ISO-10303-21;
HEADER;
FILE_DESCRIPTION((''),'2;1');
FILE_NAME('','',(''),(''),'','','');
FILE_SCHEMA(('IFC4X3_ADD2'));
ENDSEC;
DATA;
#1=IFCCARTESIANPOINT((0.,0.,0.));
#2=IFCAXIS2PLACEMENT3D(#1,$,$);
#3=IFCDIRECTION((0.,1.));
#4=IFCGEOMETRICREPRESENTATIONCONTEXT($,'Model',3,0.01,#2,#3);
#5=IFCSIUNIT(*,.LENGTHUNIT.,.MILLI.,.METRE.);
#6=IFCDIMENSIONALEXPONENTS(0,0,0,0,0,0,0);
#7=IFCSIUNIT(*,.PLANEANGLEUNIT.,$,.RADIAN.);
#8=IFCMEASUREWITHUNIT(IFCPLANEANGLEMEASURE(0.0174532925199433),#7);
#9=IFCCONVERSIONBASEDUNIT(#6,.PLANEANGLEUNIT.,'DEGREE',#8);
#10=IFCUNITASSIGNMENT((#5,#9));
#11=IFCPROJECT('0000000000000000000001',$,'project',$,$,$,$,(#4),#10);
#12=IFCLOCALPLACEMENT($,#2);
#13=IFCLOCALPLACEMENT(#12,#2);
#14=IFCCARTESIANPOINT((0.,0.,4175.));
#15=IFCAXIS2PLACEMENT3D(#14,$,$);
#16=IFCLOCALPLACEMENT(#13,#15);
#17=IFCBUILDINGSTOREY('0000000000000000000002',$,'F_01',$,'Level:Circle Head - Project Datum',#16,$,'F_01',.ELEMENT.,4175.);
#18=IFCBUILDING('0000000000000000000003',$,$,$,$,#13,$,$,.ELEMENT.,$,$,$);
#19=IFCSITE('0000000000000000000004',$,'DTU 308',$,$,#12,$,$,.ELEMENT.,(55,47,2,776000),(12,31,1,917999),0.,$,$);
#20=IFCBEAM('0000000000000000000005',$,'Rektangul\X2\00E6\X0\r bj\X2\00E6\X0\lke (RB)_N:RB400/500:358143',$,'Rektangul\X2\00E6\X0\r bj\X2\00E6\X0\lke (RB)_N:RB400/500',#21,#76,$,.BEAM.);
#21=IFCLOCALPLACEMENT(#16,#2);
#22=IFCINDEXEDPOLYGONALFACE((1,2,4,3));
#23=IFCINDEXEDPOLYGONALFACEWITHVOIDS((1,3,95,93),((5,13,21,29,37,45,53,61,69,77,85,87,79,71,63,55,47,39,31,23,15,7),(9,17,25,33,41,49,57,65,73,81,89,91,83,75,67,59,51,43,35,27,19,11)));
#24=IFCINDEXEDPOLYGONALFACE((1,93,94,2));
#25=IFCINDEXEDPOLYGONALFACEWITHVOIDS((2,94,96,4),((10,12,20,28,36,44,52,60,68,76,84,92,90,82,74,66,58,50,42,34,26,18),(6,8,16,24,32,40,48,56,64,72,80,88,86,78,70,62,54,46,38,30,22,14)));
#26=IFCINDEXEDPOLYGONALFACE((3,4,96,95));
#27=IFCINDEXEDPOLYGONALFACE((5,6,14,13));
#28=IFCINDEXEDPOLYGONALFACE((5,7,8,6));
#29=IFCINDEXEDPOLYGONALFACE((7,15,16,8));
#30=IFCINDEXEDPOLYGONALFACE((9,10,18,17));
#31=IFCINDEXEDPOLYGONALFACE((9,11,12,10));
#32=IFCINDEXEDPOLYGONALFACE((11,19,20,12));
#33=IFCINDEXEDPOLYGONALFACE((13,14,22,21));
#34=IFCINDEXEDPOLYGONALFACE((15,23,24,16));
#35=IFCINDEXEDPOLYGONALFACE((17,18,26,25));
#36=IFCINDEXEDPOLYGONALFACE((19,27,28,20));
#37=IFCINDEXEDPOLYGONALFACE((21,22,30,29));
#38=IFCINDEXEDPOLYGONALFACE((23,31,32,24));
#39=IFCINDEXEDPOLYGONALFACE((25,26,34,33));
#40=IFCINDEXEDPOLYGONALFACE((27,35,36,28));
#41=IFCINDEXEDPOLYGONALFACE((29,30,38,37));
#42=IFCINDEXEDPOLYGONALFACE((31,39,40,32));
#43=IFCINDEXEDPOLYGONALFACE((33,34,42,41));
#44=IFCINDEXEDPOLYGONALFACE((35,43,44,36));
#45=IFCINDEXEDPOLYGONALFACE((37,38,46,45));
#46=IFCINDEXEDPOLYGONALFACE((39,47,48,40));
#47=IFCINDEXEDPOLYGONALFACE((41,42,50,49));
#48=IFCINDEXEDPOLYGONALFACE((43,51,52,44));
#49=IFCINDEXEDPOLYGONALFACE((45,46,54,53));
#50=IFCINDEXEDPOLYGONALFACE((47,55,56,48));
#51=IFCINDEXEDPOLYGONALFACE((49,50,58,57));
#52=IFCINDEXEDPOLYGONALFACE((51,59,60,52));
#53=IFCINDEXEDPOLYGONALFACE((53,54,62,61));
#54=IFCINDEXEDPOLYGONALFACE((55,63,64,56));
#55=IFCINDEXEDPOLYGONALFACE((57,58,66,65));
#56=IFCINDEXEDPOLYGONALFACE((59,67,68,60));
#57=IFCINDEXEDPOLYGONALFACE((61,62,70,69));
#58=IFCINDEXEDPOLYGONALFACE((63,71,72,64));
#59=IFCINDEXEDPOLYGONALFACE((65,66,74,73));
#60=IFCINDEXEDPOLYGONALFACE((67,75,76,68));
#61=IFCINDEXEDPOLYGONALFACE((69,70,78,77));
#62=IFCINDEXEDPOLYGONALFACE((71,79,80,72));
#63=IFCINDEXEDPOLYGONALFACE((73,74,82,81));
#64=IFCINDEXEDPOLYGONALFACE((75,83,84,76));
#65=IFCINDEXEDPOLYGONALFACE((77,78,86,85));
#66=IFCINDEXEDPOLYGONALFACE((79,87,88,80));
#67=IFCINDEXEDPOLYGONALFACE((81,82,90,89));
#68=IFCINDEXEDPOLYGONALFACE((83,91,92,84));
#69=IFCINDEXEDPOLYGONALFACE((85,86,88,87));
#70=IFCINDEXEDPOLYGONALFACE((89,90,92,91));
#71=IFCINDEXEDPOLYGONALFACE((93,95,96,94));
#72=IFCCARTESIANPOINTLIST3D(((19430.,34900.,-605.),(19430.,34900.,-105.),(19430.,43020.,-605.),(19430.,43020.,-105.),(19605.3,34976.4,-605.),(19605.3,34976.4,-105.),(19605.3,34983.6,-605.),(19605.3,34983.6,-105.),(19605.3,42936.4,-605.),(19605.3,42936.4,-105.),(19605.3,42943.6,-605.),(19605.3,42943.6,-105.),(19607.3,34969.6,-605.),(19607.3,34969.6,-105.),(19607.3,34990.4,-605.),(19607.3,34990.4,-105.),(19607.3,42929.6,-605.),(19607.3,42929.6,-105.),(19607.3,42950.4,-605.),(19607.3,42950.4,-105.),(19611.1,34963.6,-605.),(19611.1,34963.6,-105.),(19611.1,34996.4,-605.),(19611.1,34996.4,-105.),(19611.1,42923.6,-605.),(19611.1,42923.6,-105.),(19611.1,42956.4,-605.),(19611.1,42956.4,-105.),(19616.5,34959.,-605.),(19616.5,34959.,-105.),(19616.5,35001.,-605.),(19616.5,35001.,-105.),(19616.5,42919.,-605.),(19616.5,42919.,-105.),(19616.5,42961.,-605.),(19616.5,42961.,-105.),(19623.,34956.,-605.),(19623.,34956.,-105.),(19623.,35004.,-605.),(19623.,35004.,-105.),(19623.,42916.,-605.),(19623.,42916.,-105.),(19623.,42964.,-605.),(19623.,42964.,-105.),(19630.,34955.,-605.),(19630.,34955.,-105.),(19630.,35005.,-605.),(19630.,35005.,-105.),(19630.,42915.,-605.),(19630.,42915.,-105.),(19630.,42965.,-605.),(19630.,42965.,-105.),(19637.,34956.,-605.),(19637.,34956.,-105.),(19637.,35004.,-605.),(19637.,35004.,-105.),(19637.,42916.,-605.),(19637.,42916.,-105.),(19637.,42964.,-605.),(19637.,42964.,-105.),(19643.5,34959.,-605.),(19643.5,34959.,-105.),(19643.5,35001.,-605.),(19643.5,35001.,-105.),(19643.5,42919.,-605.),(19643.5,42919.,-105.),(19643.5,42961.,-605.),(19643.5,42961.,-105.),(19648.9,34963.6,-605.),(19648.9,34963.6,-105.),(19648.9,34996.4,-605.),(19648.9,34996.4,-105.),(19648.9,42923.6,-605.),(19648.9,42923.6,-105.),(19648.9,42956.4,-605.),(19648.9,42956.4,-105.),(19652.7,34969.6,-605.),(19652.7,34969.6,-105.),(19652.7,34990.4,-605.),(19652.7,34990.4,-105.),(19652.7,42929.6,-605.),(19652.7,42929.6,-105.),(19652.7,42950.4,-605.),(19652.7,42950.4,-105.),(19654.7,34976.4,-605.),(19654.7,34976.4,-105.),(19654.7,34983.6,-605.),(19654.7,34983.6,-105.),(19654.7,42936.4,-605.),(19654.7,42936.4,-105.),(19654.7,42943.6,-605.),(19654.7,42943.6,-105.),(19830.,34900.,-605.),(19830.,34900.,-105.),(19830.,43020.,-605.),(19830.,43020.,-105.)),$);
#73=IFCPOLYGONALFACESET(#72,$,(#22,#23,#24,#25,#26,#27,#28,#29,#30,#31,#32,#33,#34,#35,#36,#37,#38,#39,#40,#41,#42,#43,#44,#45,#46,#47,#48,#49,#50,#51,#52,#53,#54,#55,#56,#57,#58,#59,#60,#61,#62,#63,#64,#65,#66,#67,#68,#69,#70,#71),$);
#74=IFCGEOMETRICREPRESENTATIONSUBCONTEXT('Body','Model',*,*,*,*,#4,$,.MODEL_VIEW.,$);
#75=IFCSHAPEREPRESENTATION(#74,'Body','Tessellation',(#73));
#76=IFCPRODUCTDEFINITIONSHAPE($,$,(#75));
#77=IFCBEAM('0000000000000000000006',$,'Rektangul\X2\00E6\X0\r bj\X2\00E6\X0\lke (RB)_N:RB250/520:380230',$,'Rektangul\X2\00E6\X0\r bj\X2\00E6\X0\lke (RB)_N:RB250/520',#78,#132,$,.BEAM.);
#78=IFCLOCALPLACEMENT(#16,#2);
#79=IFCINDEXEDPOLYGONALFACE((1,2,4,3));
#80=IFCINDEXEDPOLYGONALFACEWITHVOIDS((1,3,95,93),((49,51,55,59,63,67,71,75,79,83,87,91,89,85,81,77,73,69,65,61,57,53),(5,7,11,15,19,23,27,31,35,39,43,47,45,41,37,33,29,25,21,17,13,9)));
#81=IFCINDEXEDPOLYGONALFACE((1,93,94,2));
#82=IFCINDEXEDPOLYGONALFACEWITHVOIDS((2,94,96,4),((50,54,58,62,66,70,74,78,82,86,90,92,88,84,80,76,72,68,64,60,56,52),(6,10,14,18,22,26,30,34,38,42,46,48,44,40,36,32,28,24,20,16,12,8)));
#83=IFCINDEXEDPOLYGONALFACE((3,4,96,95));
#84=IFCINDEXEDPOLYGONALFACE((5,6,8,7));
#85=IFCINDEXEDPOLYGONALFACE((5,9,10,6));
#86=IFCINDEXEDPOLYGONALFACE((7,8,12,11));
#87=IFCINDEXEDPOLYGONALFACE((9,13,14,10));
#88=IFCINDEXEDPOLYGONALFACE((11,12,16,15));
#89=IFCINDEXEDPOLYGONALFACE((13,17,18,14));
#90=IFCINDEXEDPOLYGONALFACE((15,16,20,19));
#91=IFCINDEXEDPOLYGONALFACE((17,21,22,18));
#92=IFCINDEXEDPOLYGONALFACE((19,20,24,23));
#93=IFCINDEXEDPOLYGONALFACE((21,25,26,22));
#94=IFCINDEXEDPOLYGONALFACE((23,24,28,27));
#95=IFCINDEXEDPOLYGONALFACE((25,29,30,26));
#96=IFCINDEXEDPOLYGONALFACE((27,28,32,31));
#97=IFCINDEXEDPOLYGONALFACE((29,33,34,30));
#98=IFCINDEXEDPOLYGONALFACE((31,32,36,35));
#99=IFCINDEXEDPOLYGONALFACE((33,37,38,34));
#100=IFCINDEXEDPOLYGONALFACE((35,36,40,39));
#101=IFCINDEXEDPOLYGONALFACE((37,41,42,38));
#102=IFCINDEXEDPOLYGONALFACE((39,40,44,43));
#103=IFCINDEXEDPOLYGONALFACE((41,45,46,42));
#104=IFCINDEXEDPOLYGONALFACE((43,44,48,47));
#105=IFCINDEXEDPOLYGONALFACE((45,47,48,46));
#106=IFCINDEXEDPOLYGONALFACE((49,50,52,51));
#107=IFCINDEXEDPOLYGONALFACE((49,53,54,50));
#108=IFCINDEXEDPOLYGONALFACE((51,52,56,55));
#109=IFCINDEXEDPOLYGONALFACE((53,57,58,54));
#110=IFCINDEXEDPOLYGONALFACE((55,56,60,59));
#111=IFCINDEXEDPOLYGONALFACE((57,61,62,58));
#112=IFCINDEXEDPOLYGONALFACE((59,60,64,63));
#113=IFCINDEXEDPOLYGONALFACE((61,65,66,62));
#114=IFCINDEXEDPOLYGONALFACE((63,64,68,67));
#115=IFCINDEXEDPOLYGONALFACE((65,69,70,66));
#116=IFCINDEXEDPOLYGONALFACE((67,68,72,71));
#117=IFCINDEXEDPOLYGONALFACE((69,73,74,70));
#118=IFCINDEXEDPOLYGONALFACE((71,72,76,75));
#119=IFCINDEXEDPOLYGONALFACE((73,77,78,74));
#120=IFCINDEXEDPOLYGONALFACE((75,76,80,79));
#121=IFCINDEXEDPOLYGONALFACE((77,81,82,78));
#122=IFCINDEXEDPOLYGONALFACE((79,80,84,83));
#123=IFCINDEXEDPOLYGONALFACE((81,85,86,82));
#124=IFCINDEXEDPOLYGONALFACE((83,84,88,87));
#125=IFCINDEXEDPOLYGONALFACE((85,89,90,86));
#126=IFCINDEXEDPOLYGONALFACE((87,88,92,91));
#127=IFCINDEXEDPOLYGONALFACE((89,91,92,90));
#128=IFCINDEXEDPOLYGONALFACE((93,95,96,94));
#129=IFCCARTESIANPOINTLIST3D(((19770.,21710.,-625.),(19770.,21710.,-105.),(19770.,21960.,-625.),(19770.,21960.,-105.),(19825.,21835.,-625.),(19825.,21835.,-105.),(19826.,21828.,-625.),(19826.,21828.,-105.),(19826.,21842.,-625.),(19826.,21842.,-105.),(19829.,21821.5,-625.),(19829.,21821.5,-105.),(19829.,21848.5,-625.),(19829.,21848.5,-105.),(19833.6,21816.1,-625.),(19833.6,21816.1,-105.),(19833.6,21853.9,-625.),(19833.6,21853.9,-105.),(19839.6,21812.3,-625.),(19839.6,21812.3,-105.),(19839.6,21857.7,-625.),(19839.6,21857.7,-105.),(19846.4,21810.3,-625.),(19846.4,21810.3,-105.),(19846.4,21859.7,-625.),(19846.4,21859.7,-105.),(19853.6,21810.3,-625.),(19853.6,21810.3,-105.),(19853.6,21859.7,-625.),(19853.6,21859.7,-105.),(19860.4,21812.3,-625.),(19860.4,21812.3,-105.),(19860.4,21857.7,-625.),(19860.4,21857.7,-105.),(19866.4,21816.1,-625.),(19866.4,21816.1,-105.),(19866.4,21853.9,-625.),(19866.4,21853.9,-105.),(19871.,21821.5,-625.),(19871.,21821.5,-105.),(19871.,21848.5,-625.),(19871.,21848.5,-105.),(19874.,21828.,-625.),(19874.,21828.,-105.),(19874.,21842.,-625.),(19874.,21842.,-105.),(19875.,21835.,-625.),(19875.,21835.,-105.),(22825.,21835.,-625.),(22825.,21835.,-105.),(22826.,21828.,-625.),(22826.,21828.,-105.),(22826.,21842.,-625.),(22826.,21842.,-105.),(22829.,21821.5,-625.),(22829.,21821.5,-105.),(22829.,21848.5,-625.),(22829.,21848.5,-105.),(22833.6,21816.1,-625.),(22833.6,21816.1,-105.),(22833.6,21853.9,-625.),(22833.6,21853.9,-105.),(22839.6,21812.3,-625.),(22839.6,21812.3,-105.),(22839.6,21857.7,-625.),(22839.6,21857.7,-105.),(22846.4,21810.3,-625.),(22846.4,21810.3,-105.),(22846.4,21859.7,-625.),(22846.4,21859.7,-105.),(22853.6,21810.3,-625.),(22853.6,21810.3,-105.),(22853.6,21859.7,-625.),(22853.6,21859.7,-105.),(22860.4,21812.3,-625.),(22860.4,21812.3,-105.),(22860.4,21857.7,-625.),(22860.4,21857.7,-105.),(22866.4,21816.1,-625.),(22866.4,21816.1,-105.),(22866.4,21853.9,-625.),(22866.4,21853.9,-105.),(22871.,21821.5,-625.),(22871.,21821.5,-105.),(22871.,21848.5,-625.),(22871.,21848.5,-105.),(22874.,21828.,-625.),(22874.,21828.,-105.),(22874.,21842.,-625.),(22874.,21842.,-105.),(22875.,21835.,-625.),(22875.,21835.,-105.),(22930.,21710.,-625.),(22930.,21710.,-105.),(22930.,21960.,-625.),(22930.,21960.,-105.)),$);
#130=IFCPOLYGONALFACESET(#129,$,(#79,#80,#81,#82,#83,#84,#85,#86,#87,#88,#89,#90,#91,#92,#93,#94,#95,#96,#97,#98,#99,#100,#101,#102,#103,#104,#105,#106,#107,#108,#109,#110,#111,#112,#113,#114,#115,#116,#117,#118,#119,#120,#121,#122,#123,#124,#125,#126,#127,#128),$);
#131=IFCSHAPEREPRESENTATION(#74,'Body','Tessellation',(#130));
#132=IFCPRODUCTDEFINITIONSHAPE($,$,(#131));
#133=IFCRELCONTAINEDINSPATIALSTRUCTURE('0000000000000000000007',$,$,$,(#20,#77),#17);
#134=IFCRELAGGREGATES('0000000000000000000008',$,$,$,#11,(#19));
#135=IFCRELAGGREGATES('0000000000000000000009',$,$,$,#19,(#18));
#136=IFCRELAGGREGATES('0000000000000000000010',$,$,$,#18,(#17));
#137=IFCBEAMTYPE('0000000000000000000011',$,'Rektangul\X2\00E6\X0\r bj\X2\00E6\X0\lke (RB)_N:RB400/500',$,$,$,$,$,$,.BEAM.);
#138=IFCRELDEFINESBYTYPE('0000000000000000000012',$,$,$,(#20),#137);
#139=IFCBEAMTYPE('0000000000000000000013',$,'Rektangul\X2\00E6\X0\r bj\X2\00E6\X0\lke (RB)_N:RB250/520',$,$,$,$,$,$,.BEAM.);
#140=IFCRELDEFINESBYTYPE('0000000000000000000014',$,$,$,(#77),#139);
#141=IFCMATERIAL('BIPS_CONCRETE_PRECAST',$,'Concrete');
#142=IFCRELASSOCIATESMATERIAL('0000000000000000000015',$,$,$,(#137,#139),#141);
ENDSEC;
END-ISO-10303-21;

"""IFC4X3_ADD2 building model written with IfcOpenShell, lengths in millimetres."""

from ifc_helpers import new_model, entity, si_unit, converted_unit, direction, frame, frame_2d, origin, place, context, subcontext, project, spatial, polyline, circle_curve, parameter, trimmed, segment, composite_curve, rectangle, outline, extrude, source, transform, mapped, material, material_profile, profile_set, type_object, element, save


model = new_model("IFC4X3_ADD2")

# Units and contexts
model_context = context("Model", 3, precision=0.01, world=origin(), true_north=direction((0.0, 1.0)))
body_context = subcontext(model_context, "Body", "Model", "MODEL_VIEW")
ifc_project = project(units=[si_unit("LENGTHUNIT", "METRE", prefix="MILLI"), converted_unit("PLANEANGLEUNIT", "DEGREE", entity("IfcPlaneAngleMeasure", 0.0174532925199433), si_unit("PLANEANGLEUNIT", "RADIAN"), dimensions=[0, 0, 0, 0, 0, 0, 0])], contexts=[model_context])

# Site, building, storey
site_placement = place(None, origin())
site = spatial("IfcSite", under=ifc_project, at=site_placement, Name="DTU 308", CompositionType="ELEMENT", RefLatitude=(55, 47, 2, 776000), RefLongitude=(12, 31, 1, 917999), RefElevation=0.0)
building_placement = place(site_placement, origin())
building = spatial("IfcBuilding", under=site, at=building_placement, CompositionType="ELEMENT")
storey_placement = place(building_placement, frame((0.0, 0.0, 4175.0)))
storey = spatial("IfcBuildingStorey", under=building, at=storey_placement, Name="F_01", ObjectType="Level:Circle Head - Project Datum", LongName="F_01", CompositionType="ELEMENT", Elevation=4175.0)

# Beams
ifc_material_1 = material(Name="BIPS_CONCRETE_PRECAST", Category="Concrete")
ifc_material_profile_1 = material_profile(ifc_material_1, outline(polyline([(-4060.0, -200.0), (4060.0, -200.0), (4060.0, 200.0), (-4060.0, 200.0), (-4060.0, -200.0)]), holes=[composite_curve([segment(trimmed(circle_curve(frame_2d((3980.0, 0.0), x_axis=(-1.0, 0.0)), 25.0), [parameter(0.0)], [parameter(180.0)], True, "PARAMETER"), False, "CONTINUOUS"), segment(trimmed(circle_curve(frame_2d((3980.0, 0.0), x_axis=(-1.0, 0.0)), 25.0), [parameter(180.0)], [parameter(360.0)], True, "PARAMETER"), False, "CONTINUOUS")], self_intersect=False), composite_curve([segment(trimmed(circle_curve(frame_2d((-3980.0, 0.0), x_axis=(-1.0, 0.0)), 25.0), [parameter(0.0)], [parameter(180.0)], True, "PARAMETER"), False, "CONTINUOUS"), segment(trimmed(circle_curve(frame_2d((-3980.0, 0.0), x_axis=(-1.0, 0.0)), 25.0), [parameter(180.0)], [parameter(360.0)], True, "PARAMETER"), False, "CONTINUOUS")], self_intersect=False)]), Name="RB400/500")
ifc_profile_set_1 = profile_set([ifc_material_profile_1], Name="RB400/500")
beam_type_1 = type_object("IfcBeamType", Name="Rektangulær bjælke (RB)_N:RB400/500", PredefinedType="BEAM", material=ifc_profile_set_1)
shared_shape_1 = source(origin(), body_context, "Body", "SweptSolid", [
    extrude(outline(polyline([(-4060.0, -200.0), (4060.0, -200.0), (4060.0, 200.0), (-4060.0, 200.0), (-4060.0, -200.0)]), holes=[composite_curve([segment(trimmed(circle_curve(frame_2d((3980.0, 0.0), x_axis=(-1.0, 0.0)), 25.0), [parameter(0.0)], [parameter(180.0)], True, "PARAMETER"), False, "CONTINUOUS"), segment(trimmed(circle_curve(frame_2d((3980.0, 0.0), x_axis=(-1.0, 0.0)), 25.0), [parameter(180.0)], [parameter(360.0)], True, "PARAMETER"), False, "CONTINUOUS")], self_intersect=False), composite_curve([segment(trimmed(circle_curve(frame_2d((-3980.0, 0.0), x_axis=(-1.0, 0.0)), 25.0), [parameter(0.0)], [parameter(180.0)], True, "PARAMETER"), False, "CONTINUOUS"), segment(trimmed(circle_curve(frame_2d((-3980.0, 0.0), x_axis=(-1.0, 0.0)), 25.0), [parameter(180.0)], [parameter(360.0)], True, "PARAMETER"), False, "CONTINUOUS")], self_intersect=False)]), frame((10.0, 0.0, -250.0), z_axis=(0.0, 0.0, 1.0), x_axis=(-1.0, 0.0, 0.0)), (0.0, 0.0, 1.0), 500.0),
])
for number, where, z_axis, x_axis, name in (
    (1, (19630.0, 38950.0, -355.0), (0.0, 0.0, 1.0), (0.0, 1.0, 0.0), "Rektangulær bjælke (RB)_N:RB400/500:358143"),
):
    element("IfcBeam", number, at=place(storey_placement, frame(where, z_axis=z_axis, x_axis=x_axis)), inside=storey, type_object=beam_type_1, Name=name, ObjectType="Rektangulær bjælke (RB)_N:RB400/500", PredefinedType="BEAM", context=body_context, shape_type="MappedRepresentation", body=[
        mapped(shared_shape_1, transform((0.0, 0.0, 0.0), scale=1.0)),
    ])
ifc_material_profile_2 = material_profile(ifc_material_1, rectangle(XDim=520.0, YDim=250.0, at=frame_2d((0.0, 0.0), x_axis=(1.0, 0.0))), Name="RB250/520")
ifc_profile_set_2 = profile_set([ifc_material_profile_2], Name="RB250/520")
beam_type_2 = type_object("IfcBeamType", Name="Rektangulær bjælke (RB)_N:RB250/520", PredefinedType="BEAM", material=ifc_profile_set_2)
shared_shape_2 = source(origin(), body_context, "Body", "SweptSolid", [
    extrude(outline(polyline([(-1580.0, -125.0), (1580.0, -125.0), (1580.0, 125.0), (-1580.0, 125.0), (-1580.0, -125.0)]), holes=[composite_curve([segment(trimmed(circle_curve(frame_2d((1500.0, 0.0), x_axis=(-1.0, 0.0)), 25.0), [parameter(0.0)], [parameter(180.0)], True, "PARAMETER"), False, "CONTINUOUS"), segment(trimmed(circle_curve(frame_2d((1500.0, 0.0), x_axis=(-1.0, 0.0)), 25.0), [parameter(180.0)], [parameter(360.0)], True, "PARAMETER"), False, "CONTINUOUS")], self_intersect=False), composite_curve([segment(trimmed(circle_curve(frame_2d((-1500.0, 0.0), x_axis=(-1.0, 0.0)), 25.0), [parameter(0.0)], [parameter(180.0)], True, "PARAMETER"), False, "CONTINUOUS"), segment(trimmed(circle_curve(frame_2d((-1500.0, 0.0), x_axis=(-1.0, 0.0)), 25.0), [parameter(180.0)], [parameter(360.0)], True, "PARAMETER"), False, "CONTINUOUS")], self_intersect=False)]), frame((120.0, 0.0, -260.0), z_axis=(0.0, 0.0, 1.0), x_axis=(-1.0, 0.0, 0.0)), (0.0, 0.0, 1.0), 520.0),
])
beam_1_placement = place(storey_placement, frame((21230.0, 21835.0, -365.0)))
element("IfcBeam", 2, at=beam_1_placement, inside=storey, type_object=beam_type_2, Name="Rektangulær bjælke (RB)_N:RB250/520:380230", ObjectType="Rektangulær bjælke (RB)_N:RB250/520", PredefinedType="BEAM", context=body_context, shape_type="MappedRepresentation", body=[
    mapped(shared_shape_2, transform((0.0, 0.0, 0.0), scale=1.0)),
])

save(model, "model.ifc")
